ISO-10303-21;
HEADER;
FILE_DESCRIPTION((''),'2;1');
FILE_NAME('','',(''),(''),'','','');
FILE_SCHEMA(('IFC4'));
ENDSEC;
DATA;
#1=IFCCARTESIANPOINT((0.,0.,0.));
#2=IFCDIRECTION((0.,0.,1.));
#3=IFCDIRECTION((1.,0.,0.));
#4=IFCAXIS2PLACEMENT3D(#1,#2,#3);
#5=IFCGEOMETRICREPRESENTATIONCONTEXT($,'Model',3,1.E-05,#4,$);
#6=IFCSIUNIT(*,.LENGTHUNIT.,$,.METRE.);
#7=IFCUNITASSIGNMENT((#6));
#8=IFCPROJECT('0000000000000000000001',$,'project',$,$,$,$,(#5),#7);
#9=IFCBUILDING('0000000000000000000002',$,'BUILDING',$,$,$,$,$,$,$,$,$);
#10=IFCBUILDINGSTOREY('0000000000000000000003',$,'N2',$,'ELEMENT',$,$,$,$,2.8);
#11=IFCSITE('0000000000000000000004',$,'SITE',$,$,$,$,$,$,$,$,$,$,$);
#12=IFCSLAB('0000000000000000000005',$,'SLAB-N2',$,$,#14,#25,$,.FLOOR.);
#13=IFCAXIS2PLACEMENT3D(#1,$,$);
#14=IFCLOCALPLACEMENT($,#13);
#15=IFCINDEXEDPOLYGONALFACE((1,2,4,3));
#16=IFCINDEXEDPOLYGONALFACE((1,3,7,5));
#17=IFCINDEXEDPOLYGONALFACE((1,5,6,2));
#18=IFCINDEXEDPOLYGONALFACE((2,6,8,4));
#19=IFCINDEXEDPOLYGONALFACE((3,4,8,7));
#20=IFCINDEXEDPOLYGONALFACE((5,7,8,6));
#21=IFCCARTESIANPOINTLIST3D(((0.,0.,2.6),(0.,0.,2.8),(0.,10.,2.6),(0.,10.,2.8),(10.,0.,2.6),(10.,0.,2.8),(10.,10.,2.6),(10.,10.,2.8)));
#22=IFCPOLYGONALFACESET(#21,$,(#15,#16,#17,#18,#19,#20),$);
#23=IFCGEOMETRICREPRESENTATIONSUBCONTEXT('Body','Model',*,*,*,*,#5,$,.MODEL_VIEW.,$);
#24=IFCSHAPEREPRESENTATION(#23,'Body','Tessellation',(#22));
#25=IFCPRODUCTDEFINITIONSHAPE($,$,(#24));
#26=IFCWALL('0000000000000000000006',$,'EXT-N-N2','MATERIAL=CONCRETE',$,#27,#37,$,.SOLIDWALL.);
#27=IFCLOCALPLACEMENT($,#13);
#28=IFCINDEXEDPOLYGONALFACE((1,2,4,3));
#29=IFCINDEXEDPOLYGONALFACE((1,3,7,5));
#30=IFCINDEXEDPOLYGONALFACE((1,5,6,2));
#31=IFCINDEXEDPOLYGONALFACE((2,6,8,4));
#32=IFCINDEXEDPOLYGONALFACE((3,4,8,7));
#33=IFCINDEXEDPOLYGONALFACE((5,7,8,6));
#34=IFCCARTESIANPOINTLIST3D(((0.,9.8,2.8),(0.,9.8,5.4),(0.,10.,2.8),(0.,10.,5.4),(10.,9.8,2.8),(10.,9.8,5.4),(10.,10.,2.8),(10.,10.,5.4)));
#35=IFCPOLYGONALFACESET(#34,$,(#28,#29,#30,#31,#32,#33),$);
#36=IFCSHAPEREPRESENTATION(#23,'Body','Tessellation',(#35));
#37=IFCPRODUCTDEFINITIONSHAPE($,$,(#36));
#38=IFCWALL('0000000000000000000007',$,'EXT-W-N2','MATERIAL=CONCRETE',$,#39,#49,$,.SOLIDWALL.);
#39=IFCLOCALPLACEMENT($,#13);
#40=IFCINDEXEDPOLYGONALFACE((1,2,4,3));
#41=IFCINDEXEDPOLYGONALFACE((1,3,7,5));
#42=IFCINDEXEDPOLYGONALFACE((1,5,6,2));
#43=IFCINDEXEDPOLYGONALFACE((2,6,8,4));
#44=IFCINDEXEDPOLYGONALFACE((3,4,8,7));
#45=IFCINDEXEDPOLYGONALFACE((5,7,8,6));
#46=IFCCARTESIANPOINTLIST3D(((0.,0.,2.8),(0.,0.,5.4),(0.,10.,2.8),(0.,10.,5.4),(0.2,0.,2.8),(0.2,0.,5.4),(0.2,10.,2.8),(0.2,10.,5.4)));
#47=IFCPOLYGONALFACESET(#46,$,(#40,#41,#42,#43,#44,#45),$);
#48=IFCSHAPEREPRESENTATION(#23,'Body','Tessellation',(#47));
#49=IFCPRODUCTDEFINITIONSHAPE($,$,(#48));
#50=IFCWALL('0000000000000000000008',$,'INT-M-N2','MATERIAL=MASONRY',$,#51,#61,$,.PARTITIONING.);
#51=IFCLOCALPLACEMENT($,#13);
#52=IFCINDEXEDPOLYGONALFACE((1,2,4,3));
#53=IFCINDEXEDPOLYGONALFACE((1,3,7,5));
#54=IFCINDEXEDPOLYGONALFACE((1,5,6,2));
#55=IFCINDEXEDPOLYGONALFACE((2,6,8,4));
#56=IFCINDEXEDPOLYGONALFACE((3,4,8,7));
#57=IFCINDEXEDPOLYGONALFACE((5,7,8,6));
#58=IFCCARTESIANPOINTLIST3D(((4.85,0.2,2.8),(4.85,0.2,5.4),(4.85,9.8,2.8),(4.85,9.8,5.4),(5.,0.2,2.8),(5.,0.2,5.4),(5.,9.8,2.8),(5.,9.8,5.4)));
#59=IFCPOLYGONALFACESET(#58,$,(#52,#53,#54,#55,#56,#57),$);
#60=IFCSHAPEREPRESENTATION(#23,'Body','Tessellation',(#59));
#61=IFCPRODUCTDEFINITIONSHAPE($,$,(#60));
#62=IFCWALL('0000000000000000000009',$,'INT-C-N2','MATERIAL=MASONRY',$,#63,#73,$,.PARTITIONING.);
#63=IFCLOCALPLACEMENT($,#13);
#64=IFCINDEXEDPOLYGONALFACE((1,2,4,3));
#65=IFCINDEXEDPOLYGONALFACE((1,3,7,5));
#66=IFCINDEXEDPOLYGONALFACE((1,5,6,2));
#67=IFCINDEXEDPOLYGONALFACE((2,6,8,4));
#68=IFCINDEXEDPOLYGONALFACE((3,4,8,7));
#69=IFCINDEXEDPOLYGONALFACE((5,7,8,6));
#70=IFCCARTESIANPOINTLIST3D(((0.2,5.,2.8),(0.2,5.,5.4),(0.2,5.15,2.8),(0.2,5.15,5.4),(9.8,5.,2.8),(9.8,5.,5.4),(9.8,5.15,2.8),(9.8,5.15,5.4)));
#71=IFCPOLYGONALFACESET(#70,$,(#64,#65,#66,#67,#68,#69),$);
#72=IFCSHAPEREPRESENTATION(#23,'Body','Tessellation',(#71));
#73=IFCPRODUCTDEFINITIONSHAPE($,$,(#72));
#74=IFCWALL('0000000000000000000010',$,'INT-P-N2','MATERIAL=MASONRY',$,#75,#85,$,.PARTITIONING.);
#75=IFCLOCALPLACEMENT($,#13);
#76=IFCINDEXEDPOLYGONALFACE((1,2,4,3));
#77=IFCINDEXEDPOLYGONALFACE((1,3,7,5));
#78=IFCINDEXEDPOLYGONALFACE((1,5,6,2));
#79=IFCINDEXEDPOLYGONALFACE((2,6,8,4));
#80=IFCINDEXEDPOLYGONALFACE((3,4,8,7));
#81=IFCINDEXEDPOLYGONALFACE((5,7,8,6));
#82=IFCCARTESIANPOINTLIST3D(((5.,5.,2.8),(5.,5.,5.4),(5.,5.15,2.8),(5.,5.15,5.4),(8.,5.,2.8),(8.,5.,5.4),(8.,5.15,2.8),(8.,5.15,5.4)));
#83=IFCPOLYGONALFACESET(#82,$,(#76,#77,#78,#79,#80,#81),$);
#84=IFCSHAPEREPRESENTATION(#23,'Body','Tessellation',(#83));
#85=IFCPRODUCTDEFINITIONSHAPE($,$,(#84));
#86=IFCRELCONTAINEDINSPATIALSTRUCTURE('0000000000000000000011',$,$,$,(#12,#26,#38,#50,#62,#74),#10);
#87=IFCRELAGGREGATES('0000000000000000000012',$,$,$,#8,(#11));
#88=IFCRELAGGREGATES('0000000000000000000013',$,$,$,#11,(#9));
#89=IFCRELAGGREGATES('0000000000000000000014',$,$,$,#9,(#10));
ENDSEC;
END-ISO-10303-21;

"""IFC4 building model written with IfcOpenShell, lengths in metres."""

from ifc_helpers import new_model, si_unit, frame, origin_with_axes, place, context, subcontext, project, spatial, indexed_curve, outline, extrude, element, save


model = new_model("IFC4")

# Units and contexts
model_context = context("Model", 3, precision=1e-05, world=origin_with_axes())
body_context = subcontext(model_context, "Body", "Model", "MODEL_VIEW")
ifc_project = project(units=[si_unit("LENGTHUNIT", "METRE")], contexts=[model_context])

# Site, building, storey
site = spatial("IfcSite", under=ifc_project, Name="SITE")
building = spatial("IfcBuilding", under=site, Name="BUILDING")
storey = spatial("IfcBuildingStorey", under=building, Name="N2", ObjectType="ELEMENT", Elevation=2.8)

# Slab
slab_placement = place(None, frame((0.0, 0.0, 2.6), z_axis=(0.0, 0.0, 1.0), x_axis=(1.0, 0.0, 0.0)))
element("IfcSlab", 1, at=slab_placement, inside=storey, Name="SLAB-N2", PredefinedType="FLOOR", context=body_context, shape_type="SweptSolid", body=[
    extrude(outline(indexed_curve([(0.0, 0.0), (10.0, 0.0), (10.0, 10.0), (0.0, 10.0), (0.0, 0.0)])), None, (0.0, 0.0, 1.0), 0.2),
])

# Walls
for number, where, z_axis, x_axis, name in (
    (2, (10.0, 10.0, 2.8), (0.0, 0.0, 1.0), (-1.0, 0.0, 0.0), "EXT-N-N2"),
    (3, (0.0, 10.0, 2.8), (0.0, 0.0, 1.0), (0.0, -1.0, 0.0), "EXT-W-N2"),
):
    element("IfcWall", number, at=place(None, frame(where, z_axis=z_axis, x_axis=x_axis)), inside=storey, Name=name, Description="MATERIAL=CONCRETE", PredefinedType="SOLIDWALL", context=body_context, shape_type="SweptSolid", body=[
        extrude(outline(indexed_curve([(0.0, 0.0), (0.0, 0.2), (10.0, 0.2), (10.0, 0.0), (0.0, 0.0)], self_intersect=False)), origin_with_axes(), (0.0, 0.0, 1.0), 2.6),
    ])
for number, where, z_axis, x_axis, name in (
    (4, (5.0, 0.2, 2.8), (0.0, 0.0, 1.0), (0.0, 1.0, 0.0), "INT-M-N2"),
    (5, (0.2, 5.0, 2.8), (0.0, 0.0, 1.0), (1.0, 0.0, 0.0), "INT-C-N2"),
):
    element("IfcWall", number, at=place(None, frame(where, z_axis=z_axis, x_axis=x_axis)), inside=storey, Name=name, Description="MATERIAL=MASONRY", PredefinedType="PARTITIONING", context=body_context, shape_type="SweptSolid", body=[
        extrude(outline(indexed_curve([(0.0, 0.0), (0.0, 0.15), (9.6, 0.15), (9.6, 0.0), (0.0, 0.0)], self_intersect=False)), origin_with_axes(), (0.0, 0.0, 1.0), 2.6),
    ])
wall_placement = place(None, frame((5.0, 5.0, 2.8), z_axis=(0.0, 0.0, 1.0), x_axis=(1.0, 0.0, 0.0)))
element("IfcWall", 6, at=wall_placement, inside=storey, Name="INT-P-N2", Description="MATERIAL=MASONRY", PredefinedType="PARTITIONING", context=body_context, shape_type="SweptSolid", body=[
    extrude(outline(indexed_curve([(0.0, 0.0), (0.0, 0.15), (3.0, 0.15), (3.0, 0.0), (0.0, 0.0)], self_intersect=False)), origin_with_axes(), (0.0, 0.0, 1.0), 2.6),
])

save(model, "model.ifc")
